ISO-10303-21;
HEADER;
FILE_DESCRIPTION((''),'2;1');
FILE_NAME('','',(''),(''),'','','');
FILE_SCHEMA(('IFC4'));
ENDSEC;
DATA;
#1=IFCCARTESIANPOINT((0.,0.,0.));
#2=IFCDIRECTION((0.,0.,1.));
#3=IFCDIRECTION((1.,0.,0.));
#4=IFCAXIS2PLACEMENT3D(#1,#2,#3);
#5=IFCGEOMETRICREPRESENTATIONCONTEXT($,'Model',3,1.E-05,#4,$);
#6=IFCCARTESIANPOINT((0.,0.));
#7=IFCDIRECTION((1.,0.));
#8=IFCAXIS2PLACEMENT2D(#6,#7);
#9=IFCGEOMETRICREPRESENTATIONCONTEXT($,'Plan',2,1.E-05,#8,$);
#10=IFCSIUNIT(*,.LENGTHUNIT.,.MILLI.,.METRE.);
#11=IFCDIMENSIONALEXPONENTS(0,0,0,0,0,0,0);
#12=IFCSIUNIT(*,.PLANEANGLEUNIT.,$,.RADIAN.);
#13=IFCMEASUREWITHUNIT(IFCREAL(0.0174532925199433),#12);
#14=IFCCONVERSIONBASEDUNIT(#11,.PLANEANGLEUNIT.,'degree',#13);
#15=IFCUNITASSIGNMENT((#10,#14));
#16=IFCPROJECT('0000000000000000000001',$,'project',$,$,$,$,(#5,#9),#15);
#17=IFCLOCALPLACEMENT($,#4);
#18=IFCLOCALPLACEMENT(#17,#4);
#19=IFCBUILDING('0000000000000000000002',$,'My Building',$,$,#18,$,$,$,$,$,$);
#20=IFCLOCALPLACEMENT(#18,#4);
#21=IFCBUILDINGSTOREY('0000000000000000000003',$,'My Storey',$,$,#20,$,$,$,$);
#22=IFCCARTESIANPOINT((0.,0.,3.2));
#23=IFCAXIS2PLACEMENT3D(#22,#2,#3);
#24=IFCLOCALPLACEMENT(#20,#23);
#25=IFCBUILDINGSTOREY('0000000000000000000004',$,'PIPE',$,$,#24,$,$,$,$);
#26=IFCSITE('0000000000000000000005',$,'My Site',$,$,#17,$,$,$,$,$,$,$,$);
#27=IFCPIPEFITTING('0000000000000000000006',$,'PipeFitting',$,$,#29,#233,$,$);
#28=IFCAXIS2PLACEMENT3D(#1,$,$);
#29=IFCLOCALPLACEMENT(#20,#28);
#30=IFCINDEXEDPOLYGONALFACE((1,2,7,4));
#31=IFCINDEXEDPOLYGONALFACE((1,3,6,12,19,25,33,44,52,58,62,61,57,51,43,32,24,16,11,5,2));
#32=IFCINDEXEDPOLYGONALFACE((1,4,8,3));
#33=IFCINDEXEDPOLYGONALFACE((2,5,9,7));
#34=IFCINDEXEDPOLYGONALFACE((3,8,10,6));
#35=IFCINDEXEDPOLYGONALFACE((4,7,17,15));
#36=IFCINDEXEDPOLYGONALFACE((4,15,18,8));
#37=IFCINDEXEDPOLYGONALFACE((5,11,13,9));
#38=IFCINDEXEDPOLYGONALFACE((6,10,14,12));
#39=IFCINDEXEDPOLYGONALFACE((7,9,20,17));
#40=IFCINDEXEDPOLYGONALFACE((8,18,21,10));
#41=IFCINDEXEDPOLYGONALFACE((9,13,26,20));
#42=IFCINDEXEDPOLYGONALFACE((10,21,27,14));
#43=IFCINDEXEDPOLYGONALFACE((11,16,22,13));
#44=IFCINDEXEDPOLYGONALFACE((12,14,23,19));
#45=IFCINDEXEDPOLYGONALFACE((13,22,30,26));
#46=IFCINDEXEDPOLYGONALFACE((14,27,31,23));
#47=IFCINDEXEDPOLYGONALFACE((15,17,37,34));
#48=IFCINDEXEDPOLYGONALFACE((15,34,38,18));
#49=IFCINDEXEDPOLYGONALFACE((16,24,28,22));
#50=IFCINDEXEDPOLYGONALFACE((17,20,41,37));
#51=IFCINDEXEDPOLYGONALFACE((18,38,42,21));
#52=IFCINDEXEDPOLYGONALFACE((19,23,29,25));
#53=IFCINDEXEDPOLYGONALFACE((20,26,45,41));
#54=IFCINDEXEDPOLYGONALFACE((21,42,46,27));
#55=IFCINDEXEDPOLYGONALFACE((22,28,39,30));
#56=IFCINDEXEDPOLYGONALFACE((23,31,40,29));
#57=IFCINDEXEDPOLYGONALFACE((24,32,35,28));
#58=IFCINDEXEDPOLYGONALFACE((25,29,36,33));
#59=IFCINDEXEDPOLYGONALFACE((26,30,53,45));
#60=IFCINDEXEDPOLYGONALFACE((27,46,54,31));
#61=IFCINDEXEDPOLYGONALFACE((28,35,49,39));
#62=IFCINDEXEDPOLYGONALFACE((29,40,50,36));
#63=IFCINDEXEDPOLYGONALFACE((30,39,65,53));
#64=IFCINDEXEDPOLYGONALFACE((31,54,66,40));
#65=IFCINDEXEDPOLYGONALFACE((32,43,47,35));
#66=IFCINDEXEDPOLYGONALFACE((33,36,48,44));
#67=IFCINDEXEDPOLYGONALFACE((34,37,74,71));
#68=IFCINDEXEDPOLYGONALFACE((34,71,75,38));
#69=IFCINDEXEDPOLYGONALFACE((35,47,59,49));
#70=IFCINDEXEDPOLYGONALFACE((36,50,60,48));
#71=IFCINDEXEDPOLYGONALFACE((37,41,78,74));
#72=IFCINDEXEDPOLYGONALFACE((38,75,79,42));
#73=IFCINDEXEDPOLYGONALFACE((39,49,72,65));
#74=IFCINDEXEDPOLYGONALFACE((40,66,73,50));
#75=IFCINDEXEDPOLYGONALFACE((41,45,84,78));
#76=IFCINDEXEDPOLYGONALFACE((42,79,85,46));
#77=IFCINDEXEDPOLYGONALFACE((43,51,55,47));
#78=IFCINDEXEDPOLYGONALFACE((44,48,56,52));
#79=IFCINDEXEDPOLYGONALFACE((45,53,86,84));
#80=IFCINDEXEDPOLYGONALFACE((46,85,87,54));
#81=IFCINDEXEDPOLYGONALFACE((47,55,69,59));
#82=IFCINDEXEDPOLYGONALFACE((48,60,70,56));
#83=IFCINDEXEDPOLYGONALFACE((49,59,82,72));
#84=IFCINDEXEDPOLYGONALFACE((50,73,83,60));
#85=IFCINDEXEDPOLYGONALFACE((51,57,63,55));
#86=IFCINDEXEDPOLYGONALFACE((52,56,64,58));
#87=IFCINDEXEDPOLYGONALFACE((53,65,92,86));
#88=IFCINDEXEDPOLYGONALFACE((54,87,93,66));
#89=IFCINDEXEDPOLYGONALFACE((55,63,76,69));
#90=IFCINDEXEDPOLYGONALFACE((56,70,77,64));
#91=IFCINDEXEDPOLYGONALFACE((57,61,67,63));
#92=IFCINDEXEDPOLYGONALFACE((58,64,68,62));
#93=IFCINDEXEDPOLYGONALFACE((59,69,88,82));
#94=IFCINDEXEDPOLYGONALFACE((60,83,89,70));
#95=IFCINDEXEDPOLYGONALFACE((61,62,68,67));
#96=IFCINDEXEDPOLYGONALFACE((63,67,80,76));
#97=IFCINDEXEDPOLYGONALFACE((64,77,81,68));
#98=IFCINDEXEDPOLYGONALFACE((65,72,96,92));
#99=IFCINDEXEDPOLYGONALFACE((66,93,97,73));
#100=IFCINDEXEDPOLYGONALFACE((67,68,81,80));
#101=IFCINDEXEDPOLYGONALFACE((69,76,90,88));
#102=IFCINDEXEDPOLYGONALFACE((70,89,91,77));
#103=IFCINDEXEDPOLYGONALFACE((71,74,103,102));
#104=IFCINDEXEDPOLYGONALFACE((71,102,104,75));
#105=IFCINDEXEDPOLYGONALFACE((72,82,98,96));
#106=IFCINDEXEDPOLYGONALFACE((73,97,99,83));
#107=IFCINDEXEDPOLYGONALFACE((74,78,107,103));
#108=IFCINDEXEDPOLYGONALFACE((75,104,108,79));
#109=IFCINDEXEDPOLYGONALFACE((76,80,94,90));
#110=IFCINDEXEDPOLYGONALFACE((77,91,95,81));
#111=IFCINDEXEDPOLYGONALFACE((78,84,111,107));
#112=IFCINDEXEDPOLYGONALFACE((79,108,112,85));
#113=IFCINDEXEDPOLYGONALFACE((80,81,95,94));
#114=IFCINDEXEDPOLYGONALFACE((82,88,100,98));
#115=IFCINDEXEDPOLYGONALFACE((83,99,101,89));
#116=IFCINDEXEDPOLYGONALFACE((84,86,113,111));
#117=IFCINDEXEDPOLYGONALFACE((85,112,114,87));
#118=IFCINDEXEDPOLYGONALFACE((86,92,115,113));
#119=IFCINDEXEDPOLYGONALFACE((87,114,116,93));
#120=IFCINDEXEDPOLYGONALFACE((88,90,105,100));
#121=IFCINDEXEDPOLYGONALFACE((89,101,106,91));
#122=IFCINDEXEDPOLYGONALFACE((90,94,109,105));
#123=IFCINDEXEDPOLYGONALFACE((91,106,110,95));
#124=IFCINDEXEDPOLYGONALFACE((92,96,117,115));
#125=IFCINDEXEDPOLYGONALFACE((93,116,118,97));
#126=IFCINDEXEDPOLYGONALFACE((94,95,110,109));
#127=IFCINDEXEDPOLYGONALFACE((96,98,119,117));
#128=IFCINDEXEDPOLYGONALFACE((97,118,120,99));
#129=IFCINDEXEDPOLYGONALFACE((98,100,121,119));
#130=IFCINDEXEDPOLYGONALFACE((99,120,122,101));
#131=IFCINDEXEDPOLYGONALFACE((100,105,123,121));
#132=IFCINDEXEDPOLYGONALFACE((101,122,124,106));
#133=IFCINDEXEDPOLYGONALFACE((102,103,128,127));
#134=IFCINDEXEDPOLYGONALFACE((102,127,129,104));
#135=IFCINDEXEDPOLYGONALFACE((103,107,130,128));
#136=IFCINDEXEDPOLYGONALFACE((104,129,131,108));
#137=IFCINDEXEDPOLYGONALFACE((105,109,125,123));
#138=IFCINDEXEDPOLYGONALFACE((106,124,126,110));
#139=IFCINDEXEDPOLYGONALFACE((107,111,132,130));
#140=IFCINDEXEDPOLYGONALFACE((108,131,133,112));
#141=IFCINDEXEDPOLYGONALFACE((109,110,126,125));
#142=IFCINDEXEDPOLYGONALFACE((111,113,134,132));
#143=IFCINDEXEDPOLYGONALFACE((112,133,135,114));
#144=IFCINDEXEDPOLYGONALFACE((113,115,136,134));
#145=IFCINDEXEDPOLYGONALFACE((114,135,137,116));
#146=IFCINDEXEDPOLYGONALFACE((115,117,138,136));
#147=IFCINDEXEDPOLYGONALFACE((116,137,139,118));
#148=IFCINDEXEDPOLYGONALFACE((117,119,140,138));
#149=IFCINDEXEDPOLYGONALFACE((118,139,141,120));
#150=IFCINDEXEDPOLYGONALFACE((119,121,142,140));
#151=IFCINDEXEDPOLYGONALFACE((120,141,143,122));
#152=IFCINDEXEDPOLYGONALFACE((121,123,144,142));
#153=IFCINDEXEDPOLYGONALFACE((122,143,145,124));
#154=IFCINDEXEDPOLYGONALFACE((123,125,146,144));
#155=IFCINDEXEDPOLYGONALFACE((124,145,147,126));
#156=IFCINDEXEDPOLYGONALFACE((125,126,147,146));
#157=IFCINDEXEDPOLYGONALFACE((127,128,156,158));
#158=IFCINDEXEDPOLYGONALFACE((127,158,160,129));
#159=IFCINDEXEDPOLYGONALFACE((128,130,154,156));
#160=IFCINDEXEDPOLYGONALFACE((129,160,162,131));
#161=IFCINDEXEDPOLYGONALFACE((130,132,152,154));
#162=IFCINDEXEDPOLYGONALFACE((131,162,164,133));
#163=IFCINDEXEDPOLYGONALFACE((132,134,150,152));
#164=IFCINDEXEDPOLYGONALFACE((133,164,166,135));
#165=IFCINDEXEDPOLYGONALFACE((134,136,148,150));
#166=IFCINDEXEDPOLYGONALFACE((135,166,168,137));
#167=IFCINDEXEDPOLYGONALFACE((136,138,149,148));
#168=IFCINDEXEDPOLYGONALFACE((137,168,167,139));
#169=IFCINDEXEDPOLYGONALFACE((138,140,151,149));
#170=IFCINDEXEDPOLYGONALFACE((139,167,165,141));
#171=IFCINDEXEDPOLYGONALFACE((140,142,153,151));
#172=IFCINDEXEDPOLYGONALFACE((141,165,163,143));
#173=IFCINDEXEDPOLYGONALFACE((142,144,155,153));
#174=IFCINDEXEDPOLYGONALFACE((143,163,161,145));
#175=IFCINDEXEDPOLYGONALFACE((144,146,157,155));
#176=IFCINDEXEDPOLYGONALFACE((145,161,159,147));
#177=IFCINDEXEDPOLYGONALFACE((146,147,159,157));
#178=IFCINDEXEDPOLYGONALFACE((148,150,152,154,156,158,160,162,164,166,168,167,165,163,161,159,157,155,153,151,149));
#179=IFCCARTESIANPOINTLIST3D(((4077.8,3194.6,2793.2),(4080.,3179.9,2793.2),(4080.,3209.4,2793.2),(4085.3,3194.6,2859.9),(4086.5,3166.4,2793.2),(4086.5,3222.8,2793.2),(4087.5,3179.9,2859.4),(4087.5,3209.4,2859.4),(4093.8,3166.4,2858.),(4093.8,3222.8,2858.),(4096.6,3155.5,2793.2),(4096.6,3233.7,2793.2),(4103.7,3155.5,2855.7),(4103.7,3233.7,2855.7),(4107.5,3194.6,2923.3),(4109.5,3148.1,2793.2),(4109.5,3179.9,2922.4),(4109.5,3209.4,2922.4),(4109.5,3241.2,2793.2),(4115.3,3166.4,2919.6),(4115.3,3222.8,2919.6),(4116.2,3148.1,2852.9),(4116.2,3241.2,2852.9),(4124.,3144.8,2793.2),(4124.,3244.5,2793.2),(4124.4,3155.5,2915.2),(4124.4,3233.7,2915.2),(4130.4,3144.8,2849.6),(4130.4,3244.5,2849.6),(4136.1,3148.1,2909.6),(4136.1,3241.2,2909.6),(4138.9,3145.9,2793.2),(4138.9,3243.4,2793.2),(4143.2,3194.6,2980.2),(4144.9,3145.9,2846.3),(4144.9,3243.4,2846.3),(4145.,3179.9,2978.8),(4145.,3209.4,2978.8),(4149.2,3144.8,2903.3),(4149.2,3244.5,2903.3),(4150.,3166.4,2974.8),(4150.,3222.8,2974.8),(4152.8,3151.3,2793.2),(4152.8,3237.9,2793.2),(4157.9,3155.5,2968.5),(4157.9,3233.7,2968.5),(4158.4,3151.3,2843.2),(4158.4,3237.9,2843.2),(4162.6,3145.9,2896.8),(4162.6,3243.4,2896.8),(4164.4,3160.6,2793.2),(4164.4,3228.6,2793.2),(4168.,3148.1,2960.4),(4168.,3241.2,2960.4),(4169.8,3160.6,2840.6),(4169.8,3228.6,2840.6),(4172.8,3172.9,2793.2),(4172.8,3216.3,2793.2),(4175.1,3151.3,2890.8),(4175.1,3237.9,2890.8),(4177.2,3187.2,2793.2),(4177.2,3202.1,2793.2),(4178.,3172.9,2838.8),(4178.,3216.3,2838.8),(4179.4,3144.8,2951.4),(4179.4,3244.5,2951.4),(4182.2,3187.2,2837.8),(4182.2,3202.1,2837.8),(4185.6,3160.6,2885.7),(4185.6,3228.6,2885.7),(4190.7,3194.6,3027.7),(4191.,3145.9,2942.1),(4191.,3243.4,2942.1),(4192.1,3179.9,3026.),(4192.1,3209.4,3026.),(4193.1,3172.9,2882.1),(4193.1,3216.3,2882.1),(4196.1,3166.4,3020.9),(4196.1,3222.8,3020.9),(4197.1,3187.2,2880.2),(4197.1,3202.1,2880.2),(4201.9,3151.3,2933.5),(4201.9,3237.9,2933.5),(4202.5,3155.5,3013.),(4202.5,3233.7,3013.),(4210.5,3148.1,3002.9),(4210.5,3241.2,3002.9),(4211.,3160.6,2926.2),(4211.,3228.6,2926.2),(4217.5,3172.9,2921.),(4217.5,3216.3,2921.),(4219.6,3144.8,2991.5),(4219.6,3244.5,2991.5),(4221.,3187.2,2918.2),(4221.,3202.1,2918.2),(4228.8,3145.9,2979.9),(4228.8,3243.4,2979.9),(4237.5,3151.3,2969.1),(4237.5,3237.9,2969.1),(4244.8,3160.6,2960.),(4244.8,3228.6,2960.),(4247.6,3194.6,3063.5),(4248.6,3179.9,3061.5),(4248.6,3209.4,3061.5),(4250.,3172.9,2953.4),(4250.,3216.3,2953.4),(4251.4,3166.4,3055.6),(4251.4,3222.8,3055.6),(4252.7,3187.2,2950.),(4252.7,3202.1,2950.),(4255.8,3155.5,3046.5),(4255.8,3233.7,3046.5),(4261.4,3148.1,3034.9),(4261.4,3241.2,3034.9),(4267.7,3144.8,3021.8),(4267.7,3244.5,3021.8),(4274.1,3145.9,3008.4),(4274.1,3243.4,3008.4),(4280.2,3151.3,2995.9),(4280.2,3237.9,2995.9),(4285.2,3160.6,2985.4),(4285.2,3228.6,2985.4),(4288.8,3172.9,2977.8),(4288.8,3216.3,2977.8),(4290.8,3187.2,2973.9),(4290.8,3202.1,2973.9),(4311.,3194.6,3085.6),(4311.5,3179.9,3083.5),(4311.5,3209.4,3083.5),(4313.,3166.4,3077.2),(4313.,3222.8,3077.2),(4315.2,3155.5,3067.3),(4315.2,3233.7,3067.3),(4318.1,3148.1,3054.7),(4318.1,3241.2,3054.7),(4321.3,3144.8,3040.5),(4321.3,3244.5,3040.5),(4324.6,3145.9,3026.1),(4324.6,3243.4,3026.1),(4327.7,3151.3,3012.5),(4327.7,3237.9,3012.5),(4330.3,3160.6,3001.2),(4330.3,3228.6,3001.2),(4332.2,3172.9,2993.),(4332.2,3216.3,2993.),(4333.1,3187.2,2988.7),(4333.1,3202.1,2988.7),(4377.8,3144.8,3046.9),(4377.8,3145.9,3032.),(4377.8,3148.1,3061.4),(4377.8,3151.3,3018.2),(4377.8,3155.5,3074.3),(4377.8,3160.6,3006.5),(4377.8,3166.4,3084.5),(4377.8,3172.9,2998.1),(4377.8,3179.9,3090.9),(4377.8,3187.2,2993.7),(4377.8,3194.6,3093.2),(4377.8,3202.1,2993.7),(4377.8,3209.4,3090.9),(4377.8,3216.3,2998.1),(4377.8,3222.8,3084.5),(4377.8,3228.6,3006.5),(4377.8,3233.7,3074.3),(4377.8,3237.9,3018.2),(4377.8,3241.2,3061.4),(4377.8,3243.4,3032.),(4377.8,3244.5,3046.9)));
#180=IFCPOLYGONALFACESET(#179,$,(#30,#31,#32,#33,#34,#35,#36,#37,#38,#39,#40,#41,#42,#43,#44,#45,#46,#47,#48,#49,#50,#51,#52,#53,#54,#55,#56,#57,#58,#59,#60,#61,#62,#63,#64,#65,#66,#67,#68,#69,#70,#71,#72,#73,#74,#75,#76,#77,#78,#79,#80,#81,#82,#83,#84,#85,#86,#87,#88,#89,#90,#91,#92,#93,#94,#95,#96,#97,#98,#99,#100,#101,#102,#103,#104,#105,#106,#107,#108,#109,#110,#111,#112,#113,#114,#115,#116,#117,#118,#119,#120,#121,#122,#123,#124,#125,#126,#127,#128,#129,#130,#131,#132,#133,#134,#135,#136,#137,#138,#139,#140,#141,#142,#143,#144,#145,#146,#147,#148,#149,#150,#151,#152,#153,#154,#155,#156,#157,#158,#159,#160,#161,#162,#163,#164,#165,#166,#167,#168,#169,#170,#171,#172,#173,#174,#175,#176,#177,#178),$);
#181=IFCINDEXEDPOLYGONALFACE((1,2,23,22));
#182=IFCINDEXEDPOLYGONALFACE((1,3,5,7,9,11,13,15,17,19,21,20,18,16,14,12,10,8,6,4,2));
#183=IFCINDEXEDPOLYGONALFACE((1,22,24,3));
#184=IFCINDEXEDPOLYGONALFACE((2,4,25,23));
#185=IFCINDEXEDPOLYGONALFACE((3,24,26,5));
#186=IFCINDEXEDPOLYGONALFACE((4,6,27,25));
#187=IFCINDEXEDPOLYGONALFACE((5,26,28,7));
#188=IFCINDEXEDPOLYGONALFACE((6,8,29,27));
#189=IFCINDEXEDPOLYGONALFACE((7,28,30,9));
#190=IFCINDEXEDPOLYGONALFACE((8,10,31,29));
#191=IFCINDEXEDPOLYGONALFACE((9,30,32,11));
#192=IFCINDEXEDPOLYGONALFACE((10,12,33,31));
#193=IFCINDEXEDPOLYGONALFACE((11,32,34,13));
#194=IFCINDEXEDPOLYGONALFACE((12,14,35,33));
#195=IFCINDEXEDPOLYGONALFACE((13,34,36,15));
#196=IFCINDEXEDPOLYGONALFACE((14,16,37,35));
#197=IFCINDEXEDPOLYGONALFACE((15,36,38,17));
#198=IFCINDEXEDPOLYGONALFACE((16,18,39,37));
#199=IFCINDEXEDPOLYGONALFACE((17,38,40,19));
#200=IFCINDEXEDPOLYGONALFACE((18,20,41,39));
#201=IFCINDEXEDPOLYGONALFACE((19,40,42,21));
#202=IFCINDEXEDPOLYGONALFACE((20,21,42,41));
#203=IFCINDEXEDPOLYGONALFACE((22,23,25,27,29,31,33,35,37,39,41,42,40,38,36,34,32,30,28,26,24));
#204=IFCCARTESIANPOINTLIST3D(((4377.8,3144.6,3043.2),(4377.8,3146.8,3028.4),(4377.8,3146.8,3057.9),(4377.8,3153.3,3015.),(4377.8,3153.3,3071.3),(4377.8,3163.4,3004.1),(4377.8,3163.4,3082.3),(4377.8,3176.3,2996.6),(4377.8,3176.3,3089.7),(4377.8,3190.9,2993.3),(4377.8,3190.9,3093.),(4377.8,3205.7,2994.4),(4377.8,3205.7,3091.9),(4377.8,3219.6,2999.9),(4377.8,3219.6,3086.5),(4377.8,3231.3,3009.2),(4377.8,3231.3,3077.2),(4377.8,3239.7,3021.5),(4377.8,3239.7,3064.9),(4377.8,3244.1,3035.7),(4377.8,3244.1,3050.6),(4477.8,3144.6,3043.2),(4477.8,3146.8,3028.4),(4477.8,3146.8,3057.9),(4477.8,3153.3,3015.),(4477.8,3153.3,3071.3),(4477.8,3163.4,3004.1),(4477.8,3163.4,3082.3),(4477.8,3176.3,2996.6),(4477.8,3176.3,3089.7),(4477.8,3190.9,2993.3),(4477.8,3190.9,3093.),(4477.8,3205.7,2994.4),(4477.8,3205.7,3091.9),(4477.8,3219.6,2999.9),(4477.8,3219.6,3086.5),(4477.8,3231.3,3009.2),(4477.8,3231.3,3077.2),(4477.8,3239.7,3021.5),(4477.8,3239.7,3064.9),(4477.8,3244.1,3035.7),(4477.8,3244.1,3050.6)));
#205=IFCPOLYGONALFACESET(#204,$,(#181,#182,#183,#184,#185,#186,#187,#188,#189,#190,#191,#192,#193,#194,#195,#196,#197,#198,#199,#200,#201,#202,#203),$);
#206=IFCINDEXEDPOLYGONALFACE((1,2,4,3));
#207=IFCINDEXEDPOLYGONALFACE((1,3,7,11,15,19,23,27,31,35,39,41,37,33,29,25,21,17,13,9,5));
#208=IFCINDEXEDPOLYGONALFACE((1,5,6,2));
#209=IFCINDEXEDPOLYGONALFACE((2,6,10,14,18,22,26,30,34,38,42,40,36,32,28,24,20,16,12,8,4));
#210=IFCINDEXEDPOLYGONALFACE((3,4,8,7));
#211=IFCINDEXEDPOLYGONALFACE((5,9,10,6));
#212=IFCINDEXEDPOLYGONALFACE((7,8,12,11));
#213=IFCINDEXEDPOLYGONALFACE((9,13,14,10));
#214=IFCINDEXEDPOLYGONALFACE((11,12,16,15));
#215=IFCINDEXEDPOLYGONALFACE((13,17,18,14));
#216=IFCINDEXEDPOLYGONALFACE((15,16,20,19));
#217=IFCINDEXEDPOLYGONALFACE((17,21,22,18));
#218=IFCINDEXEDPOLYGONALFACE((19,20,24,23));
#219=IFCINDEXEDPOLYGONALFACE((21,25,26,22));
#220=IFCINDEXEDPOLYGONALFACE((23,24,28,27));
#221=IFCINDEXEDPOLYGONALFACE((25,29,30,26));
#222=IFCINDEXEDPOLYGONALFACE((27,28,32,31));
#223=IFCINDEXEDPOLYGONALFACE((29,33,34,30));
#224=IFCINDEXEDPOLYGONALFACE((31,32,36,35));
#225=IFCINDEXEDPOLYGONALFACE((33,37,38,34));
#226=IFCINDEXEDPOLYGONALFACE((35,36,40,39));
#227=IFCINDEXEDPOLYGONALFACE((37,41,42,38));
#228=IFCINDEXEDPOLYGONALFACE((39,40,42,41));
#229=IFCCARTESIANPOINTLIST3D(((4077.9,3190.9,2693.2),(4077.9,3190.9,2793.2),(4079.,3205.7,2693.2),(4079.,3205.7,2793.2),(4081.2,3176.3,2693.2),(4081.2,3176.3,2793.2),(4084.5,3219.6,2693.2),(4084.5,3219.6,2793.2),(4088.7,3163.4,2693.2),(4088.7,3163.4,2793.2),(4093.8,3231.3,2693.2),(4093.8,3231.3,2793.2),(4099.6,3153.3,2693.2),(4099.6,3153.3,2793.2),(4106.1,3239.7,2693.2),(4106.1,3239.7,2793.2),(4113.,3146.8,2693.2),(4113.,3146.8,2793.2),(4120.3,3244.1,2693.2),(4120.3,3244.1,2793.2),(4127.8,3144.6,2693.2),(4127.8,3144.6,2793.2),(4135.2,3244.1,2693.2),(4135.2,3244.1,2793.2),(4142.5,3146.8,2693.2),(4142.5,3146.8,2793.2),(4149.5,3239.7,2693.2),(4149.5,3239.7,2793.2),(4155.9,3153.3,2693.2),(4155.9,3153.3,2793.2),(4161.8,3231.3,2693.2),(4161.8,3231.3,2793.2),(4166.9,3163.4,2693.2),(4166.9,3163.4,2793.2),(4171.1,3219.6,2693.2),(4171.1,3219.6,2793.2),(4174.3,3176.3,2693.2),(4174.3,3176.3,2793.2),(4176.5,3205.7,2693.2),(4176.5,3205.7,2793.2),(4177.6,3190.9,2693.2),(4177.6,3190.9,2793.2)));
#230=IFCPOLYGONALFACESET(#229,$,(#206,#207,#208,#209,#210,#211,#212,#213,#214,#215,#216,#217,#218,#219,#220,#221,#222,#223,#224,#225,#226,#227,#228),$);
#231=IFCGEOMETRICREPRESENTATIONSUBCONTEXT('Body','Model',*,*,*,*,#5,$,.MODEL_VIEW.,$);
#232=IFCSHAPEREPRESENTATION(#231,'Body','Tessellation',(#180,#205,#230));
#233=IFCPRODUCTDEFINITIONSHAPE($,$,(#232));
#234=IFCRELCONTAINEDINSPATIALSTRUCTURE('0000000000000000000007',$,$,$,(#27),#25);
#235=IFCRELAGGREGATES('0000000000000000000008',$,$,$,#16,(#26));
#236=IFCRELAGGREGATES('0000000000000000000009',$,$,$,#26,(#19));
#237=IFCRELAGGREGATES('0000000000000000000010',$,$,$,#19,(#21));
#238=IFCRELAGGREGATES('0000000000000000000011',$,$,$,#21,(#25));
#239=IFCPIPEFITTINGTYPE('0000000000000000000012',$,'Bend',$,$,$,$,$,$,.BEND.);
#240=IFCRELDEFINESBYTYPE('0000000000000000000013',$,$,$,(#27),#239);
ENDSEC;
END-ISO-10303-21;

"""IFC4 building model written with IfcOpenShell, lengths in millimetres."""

from ifc_helpers import new_model, entity, si_unit, converted_unit, frame, origin_with_axes, origin_2d_with_axis, place, context, subcontext, project, spatial, circle, extrude, source, transform, mapped, type_object, type_shapes, element, save


model = new_model("IFC4")

# Units and contexts
model_context = context("Model", 3, precision=1e-05, world=origin_with_axes())
plan_context = context("Plan", 2, precision=1e-05, world=origin_2d_with_axis())
body_context = subcontext(model_context, "Body", "Model", "MODEL_VIEW")
ifc_project = project(units=[si_unit("LENGTHUNIT", "METRE", prefix="MILLI"), converted_unit("PLANEANGLEUNIT", "degree", entity("IfcReal", 0.0174532925199433), si_unit("PLANEANGLEUNIT", "RADIAN"), dimensions=[0, 0, 0, 0, 0, 0, 0])], contexts=[model_context, plan_context])

# Site, building, storeys
site_placement = place(None, origin_with_axes())
site = spatial("IfcSite", under=ifc_project, at=site_placement, Name="My Site")
building_placement = place(site_placement, origin_with_axes())
building = spatial("IfcBuilding", under=site, at=building_placement, Name="My Building")
storey_1_placement = place(building_placement, origin_with_axes())
storey_1 = spatial("IfcBuildingStorey", under=building, at=storey_1_placement, Name="My Storey")
storey_2_placement = place(storey_1_placement, frame((0.0, 0.0, 3.2), z_axis=(0.0, 0.0, 1.0), x_axis=(1.0, 0.0, 0.0)))
storey_2 = spatial("IfcBuildingStorey", under=storey_1, at=storey_2_placement, Name="PIPE")

# Pipe fitting
pipe_fitting_type = type_object("IfcPipeFittingType", Name="Bend", PredefinedType="BEND")
shared_shape = source(origin_with_axes(), body_context, "Body", "SolidModel", [
    entity("IfcSweptDiskSolid", entity("IfcIndexedPolyCurve", entity("IfcCartesianPointList3D", [[0.0, 0.0, 100.0], [0.0, -73.2, 276.8], [0.0, -250.0, 350.0]]), [entity("IfcArcIndex", [1, 2, 3])]), 50.0),
    extrude(circle(Radius=50.0), origin_with_axes(), (0.0, 0.0, 1.0), 100.0),
    extrude(circle(Radius=50.0), frame((0.0, -250.0, 350.0), z_axis=(0.0, -1.0, 0.0), x_axis=(1.0, 0.0, 0.0)), (0.0, 0.0, 1.0), 100.0),
])
type_shapes(pipe_fitting_type, [shared_shape])
for number, where, z_axis, x_axis, name in (
    (1, (4477.8, 3194.6, 3040.0), (-1.0, 0.0, 0.0), (0.0, -1.0, 0.0), "PipeFitting"),
):
    element("IfcPipeFitting", number, at=place(storey_2_placement, frame(where, z_axis=z_axis, x_axis=x_axis)), inside=storey_2, type_object=pipe_fitting_type, Name=name, context=body_context, shape_type="MappedRepresentation", body=[
        mapped(shared_shape, transform((0.0, 0.0, 0.0), x_axis=(1.0, 0.0, 0.0), y_axis=(0.0, 1.0, 0.0), z_axis=(0.0, 0.0, 1.0), scale=1.0)),
    ])

save(model, "model.ifc")
